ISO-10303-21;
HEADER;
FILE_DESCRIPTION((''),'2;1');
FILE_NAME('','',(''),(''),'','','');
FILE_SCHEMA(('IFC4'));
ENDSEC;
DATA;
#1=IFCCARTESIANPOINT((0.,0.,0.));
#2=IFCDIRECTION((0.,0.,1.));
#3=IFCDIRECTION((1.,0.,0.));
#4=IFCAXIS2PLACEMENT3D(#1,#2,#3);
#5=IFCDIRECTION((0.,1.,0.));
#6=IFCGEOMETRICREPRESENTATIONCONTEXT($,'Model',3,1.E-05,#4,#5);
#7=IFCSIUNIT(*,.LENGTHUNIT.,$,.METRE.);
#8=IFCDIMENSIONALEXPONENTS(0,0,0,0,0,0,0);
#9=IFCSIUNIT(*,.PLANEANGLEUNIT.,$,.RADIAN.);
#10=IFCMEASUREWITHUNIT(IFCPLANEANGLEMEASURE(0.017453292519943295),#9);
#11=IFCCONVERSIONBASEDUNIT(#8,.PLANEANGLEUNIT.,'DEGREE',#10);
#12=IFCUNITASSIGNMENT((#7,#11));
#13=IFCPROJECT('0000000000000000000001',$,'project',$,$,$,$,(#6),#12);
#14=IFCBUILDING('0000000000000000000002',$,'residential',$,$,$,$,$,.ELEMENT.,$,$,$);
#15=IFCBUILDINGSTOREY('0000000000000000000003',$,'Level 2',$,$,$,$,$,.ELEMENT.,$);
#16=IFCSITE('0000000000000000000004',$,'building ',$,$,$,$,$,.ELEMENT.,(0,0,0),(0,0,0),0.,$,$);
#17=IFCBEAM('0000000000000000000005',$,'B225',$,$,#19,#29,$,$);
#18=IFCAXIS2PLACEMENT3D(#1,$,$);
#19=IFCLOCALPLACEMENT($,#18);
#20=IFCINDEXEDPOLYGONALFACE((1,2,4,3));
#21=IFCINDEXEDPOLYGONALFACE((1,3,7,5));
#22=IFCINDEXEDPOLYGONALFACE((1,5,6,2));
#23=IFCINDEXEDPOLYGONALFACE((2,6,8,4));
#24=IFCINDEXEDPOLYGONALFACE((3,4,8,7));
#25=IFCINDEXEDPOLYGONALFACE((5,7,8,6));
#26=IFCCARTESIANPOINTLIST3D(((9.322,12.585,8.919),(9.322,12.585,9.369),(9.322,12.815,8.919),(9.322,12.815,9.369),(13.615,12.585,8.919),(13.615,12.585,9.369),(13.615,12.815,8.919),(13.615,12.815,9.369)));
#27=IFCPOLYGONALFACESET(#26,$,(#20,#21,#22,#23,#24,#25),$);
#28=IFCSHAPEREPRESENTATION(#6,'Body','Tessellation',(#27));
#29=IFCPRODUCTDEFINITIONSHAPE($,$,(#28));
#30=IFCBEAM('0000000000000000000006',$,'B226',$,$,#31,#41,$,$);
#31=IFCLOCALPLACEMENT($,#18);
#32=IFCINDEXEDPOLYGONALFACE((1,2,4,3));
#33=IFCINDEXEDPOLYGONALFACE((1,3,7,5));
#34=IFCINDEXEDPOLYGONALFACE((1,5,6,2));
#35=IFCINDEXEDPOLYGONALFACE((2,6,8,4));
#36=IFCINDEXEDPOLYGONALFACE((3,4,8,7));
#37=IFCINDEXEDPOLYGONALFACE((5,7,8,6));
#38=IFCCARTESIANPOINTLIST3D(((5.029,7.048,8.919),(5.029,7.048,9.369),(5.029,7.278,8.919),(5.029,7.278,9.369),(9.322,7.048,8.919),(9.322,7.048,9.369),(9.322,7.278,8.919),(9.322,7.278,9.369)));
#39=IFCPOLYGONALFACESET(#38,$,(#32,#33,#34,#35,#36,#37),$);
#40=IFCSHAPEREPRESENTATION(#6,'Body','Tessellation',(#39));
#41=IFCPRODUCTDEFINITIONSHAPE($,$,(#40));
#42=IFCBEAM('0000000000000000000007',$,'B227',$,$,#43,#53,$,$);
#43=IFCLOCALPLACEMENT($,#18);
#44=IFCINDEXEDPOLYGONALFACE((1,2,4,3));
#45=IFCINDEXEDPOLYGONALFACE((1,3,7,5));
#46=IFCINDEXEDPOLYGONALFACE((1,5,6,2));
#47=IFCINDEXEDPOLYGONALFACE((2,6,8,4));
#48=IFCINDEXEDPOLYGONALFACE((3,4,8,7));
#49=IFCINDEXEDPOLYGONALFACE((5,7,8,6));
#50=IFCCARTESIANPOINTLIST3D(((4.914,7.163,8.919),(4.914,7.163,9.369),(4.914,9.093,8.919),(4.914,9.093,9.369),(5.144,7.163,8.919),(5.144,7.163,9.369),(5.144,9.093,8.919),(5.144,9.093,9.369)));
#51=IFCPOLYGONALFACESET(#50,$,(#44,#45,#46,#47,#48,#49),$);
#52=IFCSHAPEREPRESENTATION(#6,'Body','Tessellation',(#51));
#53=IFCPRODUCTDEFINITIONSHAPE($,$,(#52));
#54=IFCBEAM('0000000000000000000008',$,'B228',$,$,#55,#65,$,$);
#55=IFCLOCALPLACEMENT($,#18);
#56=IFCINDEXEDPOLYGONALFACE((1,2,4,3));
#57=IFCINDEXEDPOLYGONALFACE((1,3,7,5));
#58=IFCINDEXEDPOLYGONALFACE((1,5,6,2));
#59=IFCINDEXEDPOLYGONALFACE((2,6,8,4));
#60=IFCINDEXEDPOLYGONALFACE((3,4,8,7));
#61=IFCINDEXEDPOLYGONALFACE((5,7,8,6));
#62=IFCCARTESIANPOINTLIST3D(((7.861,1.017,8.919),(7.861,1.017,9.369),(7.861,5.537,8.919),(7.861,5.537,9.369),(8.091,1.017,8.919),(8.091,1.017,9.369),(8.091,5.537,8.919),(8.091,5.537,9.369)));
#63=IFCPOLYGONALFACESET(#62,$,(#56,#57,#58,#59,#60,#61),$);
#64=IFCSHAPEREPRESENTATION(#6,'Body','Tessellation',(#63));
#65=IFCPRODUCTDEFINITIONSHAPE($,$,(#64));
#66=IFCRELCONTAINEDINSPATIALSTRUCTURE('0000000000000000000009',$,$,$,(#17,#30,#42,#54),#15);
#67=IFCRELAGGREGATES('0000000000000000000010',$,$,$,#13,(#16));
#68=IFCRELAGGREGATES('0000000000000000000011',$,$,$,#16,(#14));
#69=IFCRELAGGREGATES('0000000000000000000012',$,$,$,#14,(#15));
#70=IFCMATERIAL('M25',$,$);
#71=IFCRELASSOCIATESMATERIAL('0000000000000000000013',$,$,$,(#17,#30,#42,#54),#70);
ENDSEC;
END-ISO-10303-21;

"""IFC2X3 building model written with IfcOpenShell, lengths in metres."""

from ifc_helpers import new_model, entity, si_unit, converted_unit, direction, frame, frame_2d, origin_with_axes, place, context, project, spatial, rectangle, extrude, material, element, save


model = new_model("IFC2X3")

# Units and contexts
model_context = context("Model", 3, precision=1e-05, world=origin_with_axes(), true_north=direction((0.0, 1.0, 0.0)))
ifc_project = project(units=[si_unit("LENGTHUNIT", "METRE"), converted_unit("PLANEANGLEUNIT", "DEGREE", entity("IfcPlaneAngleMeasure", 0.017453292519943295), si_unit("PLANEANGLEUNIT", "RADIAN"), dimensions=[0, 0, 0, 0, 0, 0, 0])], contexts=[model_context])

# Site, building, storey
site = spatial("IfcSite", under=ifc_project, Name="building ", CompositionType="ELEMENT", RefLatitude=(0, 0, 0), RefLongitude=(0, 0, 0), RefElevation=0.0)
building = spatial("IfcBuilding", under=site, Name="residential", CompositionType="ELEMENT")
storey = spatial("IfcBuildingStorey", under=building, Name="Level 2", CompositionType="ELEMENT")

# Beams
ifc_material = material(Name="M25")
placement = place(None, origin_with_axes())
element("IfcBeam", 1, at=placement, inside=storey, material=ifc_material, Name="B225", context=model_context, shape_type="SweptSolid", body=[
    extrude(rectangle(XDim=0.23, YDim=0.45, at=frame_2d((0.0, 0.0), x_axis=(0.0, 1.0, 0.0))), frame((9.322, 12.7, 9.144), z_axis=(1.0, 0.0, 0.0), x_axis=(0.0, 0.0, -1.0)), (0.0, 0.0, 1.0), 4.293),
])
element("IfcBeam", 2, at=placement, inside=storey, material=ifc_material, Name="B226", context=model_context, shape_type="SweptSolid", body=[
    extrude(rectangle(XDim=0.23, YDim=0.45, at=frame_2d((0.0, 0.0), x_axis=(0.0, 1.0, 0.0))), frame((5.029, 7.163, 9.144), z_axis=(1.0, 0.0, 0.0), x_axis=(0.0, 0.0, -1.0)), (0.0, 0.0, 1.0), 4.293),
])
element("IfcBeam", 3, at=placement, inside=storey, material=ifc_material, Name="B227", context=model_context, shape_type="SweptSolid", body=[
    extrude(rectangle(XDim=0.23, YDim=0.45, at=frame_2d((0.0, 0.0), x_axis=(0.0, 1.0, 0.0))), frame((5.029, 9.093, 9.144), z_axis=(0.0, -1.0, 0.0), x_axis=(0.0, 0.0, -1.0)), (0.0, 0.0, 1.0), 1.93),
])
element("IfcBeam", 4, at=placement, inside=storey, material=ifc_material, Name="B228", context=model_context, shape_type="SweptSolid", body=[
    extrude(rectangle(XDim=0.23, YDim=0.45, at=frame_2d((0.0, 0.0), x_axis=(0.0, 1.0, 0.0))), frame((7.976, 1.017, 9.144), z_axis=(0.0, 1.0, 0.0), x_axis=(0.0, 0.0, -1.0)), (0.0, 0.0, 1.0), 4.52),
])

save(model, "model.ifc")
